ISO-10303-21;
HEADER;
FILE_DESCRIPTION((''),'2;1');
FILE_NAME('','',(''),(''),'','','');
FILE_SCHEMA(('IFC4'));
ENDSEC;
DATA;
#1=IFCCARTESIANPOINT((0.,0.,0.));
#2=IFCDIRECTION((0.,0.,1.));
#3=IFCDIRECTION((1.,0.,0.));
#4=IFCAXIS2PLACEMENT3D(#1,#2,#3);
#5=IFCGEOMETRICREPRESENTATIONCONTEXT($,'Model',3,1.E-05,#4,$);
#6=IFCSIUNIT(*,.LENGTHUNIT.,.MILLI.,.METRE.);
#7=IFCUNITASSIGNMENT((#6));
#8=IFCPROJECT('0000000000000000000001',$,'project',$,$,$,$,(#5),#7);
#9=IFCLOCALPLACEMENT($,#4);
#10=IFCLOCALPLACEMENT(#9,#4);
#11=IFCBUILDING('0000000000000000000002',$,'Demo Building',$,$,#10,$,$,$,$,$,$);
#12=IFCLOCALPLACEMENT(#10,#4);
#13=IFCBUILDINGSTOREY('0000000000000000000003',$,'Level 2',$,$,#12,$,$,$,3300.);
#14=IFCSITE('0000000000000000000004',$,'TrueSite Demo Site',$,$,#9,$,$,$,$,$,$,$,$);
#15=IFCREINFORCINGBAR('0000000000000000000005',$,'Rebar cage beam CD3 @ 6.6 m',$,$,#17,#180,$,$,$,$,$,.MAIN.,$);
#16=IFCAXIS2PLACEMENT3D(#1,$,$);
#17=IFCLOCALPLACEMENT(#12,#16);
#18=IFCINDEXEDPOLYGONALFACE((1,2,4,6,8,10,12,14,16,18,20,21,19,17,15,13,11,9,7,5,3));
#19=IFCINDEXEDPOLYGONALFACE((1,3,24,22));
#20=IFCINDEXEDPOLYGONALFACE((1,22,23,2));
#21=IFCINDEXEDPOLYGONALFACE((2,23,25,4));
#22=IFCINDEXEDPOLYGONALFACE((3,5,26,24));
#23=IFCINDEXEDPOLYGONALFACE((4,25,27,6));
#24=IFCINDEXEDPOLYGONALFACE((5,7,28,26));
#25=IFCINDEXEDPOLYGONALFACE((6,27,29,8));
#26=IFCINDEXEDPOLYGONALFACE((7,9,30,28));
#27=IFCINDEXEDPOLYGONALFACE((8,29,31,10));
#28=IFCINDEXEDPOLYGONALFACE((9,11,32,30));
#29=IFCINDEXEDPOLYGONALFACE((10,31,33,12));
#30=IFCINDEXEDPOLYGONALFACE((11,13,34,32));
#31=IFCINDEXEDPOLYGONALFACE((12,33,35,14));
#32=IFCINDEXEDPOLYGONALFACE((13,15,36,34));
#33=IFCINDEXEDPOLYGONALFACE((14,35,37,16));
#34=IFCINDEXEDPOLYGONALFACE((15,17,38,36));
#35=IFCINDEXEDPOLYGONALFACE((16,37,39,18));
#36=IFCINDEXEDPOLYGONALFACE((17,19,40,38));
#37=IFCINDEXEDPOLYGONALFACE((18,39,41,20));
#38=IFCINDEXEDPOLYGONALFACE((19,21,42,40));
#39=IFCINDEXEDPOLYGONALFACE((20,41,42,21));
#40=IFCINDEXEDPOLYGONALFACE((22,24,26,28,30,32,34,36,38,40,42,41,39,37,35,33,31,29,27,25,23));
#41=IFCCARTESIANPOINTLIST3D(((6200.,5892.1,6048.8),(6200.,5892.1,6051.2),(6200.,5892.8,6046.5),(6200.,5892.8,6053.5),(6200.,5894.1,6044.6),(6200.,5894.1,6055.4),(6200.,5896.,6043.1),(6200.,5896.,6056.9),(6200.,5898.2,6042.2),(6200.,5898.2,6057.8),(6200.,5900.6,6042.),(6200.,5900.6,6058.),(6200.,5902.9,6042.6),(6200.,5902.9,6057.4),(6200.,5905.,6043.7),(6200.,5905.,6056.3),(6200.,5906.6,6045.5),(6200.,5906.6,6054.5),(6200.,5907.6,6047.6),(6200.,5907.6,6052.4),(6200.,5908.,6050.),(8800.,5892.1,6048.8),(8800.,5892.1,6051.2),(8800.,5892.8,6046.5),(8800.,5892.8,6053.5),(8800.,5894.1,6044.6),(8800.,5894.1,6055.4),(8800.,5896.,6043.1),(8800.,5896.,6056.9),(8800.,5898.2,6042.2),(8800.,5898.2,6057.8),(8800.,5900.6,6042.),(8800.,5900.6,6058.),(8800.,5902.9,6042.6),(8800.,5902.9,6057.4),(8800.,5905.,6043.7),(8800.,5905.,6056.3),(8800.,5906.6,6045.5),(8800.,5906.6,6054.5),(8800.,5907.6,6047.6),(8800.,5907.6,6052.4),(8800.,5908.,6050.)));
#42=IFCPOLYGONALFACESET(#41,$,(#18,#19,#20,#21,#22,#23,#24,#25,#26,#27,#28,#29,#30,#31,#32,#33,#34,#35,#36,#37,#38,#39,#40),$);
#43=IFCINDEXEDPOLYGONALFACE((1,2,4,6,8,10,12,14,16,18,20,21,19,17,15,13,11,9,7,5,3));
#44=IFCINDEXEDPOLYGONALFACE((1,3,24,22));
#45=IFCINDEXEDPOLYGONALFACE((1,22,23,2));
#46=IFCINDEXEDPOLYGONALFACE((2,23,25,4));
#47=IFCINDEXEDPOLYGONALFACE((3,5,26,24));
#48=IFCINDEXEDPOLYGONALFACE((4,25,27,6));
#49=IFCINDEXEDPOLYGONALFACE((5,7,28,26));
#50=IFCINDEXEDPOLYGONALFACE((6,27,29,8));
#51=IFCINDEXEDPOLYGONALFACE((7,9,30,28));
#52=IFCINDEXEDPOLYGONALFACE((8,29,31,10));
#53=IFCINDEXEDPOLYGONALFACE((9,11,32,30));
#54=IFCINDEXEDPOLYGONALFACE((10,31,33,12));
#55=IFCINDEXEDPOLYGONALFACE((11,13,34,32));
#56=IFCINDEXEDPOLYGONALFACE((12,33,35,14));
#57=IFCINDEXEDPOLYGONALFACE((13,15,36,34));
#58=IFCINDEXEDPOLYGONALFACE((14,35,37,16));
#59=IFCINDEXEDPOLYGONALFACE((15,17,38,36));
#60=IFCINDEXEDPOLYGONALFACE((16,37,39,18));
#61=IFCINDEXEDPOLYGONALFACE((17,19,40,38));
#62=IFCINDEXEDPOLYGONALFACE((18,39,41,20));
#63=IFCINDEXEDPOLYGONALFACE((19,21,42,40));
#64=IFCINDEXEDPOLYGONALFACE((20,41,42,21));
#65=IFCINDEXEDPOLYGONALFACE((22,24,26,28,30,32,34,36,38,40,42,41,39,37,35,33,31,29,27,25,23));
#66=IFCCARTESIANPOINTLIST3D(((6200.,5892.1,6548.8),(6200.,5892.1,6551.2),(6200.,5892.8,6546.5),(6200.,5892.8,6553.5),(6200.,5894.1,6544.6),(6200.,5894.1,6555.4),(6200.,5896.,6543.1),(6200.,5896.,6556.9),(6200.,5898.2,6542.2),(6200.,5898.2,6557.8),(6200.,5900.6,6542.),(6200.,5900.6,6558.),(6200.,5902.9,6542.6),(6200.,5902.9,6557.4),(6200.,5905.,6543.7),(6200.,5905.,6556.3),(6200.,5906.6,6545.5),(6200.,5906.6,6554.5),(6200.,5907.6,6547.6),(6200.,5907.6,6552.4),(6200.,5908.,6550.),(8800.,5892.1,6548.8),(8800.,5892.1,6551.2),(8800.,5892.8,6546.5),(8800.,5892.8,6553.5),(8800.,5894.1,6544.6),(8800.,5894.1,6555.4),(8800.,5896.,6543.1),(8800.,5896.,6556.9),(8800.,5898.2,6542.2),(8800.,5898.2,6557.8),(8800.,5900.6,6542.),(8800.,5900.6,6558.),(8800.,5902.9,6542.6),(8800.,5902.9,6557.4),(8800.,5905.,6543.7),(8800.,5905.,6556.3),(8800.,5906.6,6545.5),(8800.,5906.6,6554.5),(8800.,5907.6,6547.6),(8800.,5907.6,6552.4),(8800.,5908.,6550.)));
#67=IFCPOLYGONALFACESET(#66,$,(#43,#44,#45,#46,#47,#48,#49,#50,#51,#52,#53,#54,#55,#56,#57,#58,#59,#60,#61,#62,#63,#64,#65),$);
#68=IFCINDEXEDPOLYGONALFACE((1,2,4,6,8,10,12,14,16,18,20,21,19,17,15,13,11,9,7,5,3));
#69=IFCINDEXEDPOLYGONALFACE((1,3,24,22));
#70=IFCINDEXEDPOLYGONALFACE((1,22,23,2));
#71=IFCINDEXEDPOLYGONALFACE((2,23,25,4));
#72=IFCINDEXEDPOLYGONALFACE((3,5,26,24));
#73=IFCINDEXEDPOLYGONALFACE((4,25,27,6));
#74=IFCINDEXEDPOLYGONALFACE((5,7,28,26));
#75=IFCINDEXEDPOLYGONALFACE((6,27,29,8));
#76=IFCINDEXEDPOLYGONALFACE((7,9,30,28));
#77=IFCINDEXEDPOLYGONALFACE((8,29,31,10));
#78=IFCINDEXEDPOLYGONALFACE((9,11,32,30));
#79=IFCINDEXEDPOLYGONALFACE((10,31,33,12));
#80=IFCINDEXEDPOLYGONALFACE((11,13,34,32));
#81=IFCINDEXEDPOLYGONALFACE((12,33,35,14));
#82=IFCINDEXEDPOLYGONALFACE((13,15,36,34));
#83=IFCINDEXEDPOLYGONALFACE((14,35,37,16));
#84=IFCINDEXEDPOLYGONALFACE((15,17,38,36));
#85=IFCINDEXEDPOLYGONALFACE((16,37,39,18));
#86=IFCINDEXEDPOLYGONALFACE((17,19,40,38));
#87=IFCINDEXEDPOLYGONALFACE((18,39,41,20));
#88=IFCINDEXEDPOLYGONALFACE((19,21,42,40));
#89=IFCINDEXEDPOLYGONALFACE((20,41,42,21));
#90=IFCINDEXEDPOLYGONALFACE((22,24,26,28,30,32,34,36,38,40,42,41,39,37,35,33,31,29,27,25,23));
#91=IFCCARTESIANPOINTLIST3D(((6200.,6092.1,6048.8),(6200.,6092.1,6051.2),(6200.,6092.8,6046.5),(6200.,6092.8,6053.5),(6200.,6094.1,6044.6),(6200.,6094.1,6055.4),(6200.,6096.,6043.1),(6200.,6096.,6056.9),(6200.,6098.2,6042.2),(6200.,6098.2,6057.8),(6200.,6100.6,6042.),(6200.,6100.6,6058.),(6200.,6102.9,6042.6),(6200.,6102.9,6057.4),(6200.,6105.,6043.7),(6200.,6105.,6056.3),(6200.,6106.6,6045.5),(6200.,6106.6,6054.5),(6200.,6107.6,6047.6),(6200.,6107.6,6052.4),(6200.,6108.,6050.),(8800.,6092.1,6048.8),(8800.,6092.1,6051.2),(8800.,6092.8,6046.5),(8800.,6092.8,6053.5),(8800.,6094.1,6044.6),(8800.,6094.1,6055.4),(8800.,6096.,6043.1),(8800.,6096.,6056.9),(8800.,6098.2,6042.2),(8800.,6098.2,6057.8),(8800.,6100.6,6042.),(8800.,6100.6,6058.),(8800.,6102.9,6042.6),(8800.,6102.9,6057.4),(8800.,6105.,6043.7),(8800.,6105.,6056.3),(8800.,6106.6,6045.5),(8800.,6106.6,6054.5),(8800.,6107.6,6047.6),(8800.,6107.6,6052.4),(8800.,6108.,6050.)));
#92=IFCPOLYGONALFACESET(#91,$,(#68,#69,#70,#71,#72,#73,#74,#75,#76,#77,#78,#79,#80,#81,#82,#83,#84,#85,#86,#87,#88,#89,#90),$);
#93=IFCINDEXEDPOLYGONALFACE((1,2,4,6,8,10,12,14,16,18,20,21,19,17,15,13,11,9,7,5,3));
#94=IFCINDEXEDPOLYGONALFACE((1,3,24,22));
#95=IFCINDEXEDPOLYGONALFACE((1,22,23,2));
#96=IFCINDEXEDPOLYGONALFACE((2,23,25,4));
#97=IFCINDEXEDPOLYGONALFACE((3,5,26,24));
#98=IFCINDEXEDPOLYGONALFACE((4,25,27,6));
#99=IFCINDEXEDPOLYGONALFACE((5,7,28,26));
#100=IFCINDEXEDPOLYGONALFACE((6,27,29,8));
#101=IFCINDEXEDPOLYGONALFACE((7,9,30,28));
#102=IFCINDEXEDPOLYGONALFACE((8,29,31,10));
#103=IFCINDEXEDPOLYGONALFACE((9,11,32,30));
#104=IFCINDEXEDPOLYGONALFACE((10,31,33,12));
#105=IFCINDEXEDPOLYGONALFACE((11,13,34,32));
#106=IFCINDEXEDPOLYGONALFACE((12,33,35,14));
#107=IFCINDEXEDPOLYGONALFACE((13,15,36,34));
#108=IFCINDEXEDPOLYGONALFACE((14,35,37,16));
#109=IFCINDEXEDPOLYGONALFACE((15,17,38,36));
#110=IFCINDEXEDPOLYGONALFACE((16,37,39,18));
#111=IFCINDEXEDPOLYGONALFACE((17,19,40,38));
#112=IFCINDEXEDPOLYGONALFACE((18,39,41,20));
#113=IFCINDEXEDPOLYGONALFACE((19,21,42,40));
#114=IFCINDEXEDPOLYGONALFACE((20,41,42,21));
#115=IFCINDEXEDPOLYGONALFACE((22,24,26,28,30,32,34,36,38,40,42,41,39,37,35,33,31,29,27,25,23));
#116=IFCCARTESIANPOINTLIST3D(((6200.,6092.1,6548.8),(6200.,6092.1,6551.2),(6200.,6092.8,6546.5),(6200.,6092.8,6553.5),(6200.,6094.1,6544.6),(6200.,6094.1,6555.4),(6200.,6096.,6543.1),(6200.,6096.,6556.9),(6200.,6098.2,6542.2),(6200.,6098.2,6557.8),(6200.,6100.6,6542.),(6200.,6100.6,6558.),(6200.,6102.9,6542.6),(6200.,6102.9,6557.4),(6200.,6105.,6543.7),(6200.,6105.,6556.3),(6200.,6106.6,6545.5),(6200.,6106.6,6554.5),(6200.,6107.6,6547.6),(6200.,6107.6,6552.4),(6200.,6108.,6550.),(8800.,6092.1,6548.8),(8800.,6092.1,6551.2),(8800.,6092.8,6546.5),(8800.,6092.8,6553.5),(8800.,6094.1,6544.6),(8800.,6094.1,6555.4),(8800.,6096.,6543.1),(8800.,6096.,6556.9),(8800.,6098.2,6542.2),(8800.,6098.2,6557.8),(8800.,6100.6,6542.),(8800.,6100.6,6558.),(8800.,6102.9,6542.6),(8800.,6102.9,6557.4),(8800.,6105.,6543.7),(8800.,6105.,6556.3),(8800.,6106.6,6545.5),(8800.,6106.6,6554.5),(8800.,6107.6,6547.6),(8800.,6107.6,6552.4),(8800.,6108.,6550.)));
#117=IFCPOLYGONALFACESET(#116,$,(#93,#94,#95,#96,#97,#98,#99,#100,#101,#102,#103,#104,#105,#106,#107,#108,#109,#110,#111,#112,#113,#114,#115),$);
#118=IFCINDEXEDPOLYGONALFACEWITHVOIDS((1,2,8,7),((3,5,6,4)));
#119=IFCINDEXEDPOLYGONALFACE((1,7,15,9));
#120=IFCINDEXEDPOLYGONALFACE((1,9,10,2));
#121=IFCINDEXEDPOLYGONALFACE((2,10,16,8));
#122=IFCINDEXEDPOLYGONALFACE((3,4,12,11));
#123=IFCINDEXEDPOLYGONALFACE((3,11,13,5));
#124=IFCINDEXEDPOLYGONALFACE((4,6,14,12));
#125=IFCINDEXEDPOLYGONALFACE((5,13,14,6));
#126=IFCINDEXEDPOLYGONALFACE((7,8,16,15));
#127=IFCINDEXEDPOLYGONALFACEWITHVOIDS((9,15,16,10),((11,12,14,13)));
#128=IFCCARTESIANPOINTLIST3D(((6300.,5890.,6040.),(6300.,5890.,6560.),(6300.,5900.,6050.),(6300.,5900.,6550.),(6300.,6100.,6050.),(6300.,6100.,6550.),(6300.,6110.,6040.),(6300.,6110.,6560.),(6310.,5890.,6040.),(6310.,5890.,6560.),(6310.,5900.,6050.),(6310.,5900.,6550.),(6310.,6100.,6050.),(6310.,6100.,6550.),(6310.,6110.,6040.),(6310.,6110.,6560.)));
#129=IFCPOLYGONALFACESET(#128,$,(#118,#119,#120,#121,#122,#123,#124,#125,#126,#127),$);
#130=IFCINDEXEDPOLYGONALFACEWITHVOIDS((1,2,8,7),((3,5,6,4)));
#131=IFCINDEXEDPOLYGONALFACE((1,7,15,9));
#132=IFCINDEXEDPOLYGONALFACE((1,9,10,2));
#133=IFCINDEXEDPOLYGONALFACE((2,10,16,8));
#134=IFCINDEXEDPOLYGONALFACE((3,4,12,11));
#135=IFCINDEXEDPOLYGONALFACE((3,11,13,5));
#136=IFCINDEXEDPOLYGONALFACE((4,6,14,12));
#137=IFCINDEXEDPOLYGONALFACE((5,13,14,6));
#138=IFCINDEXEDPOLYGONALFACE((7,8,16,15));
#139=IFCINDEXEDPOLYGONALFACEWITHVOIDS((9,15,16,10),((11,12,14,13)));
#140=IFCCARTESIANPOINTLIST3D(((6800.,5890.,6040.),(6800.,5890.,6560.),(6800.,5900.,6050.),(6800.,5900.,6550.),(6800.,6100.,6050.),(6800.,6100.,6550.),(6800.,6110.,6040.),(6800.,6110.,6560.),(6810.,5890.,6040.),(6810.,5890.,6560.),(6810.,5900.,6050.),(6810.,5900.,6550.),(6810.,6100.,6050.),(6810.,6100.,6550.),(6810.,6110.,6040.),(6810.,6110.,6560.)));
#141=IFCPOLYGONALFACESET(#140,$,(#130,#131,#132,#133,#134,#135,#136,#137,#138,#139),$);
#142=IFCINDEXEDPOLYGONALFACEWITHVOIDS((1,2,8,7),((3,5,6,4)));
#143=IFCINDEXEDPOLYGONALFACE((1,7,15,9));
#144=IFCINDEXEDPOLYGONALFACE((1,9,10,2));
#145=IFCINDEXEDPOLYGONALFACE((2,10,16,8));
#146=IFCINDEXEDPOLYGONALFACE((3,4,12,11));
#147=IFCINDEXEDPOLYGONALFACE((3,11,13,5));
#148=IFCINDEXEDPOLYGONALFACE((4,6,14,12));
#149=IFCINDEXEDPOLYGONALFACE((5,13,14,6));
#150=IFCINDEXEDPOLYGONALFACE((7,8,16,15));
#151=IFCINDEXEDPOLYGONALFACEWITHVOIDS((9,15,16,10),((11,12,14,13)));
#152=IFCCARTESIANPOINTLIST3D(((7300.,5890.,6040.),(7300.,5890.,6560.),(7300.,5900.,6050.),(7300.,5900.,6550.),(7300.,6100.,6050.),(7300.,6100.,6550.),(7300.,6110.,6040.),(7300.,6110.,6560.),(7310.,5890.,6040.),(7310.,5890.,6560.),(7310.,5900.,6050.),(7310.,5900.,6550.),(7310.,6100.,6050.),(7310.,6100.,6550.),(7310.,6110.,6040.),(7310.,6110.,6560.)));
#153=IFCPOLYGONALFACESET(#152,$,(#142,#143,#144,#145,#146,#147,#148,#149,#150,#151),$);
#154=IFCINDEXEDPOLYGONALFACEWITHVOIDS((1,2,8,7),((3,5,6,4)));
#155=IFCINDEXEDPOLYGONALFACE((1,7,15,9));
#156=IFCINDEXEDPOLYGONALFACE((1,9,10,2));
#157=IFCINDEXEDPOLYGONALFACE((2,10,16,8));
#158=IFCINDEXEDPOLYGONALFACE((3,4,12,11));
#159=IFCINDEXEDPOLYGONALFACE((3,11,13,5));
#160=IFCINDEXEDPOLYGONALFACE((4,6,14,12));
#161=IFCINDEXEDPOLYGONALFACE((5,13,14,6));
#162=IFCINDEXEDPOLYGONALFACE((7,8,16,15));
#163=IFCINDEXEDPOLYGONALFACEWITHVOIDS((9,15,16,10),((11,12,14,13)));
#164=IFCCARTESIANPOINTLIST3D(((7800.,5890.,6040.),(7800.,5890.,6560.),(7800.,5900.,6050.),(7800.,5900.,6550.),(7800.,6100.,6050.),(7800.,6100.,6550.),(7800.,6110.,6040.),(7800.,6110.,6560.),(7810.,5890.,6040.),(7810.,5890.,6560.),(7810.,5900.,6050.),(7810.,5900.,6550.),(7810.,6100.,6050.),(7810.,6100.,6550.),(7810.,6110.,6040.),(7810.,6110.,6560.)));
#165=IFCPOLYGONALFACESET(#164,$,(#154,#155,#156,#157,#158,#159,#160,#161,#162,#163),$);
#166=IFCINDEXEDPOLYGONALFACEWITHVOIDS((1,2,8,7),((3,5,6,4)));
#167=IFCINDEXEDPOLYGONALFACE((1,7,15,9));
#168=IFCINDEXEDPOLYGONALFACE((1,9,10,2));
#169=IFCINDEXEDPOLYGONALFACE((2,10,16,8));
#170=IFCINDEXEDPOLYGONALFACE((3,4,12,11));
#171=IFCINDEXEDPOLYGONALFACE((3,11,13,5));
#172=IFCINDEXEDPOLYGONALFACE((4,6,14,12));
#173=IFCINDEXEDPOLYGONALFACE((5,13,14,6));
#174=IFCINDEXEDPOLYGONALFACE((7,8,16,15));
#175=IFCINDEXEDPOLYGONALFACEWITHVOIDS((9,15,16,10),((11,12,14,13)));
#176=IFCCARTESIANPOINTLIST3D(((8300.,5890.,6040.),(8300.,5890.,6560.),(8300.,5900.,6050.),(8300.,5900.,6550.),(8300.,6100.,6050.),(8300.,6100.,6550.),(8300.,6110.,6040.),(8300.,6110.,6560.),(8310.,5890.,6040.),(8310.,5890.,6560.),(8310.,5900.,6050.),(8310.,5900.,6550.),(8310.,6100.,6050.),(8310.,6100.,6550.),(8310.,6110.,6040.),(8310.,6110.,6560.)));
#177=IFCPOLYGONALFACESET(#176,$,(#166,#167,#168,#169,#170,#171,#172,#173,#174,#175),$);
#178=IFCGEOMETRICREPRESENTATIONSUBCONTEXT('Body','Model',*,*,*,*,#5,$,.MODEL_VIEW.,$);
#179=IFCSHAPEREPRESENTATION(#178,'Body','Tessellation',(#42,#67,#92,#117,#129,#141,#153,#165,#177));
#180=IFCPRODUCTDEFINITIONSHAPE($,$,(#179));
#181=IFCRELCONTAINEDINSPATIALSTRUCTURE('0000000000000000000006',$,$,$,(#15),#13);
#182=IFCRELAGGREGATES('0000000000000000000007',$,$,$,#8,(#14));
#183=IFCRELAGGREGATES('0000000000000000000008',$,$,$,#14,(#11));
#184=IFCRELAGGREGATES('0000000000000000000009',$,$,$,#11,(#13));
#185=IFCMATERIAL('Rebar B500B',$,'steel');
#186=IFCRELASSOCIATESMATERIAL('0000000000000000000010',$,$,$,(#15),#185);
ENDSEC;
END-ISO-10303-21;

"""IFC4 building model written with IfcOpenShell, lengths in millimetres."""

from ifc_helpers import new_model, si_unit, frame, origin_with_axes, place, context, subcontext, project, spatial, hollow_rectangle, circle, extrude, material, element, save


model = new_model("IFC4")

# Units and contexts
model_context = context("Model", 3, precision=1e-05, world=origin_with_axes())
body_context = subcontext(model_context, "Body", "Model", "MODEL_VIEW")
ifc_project = project(units=[si_unit("LENGTHUNIT", "METRE", prefix="MILLI")], contexts=[model_context])

# Site, building, storey
site_placement = place(None, origin_with_axes())
site = spatial("IfcSite", under=ifc_project, at=site_placement, Name="TrueSite Demo Site")
building_placement = place(site_placement, origin_with_axes())
building = spatial("IfcBuilding", under=site, at=building_placement, Name="Demo Building")
storey_placement = place(building_placement, origin_with_axes())
storey = spatial("IfcBuildingStorey", under=building, at=storey_placement, Name="Level 2", Elevation=3300.0)

# Reinforcing bar
ifc_material_1 = material(Name="Rebar B500B", Category="steel")
for number, where, z_axis, x_axis, name in (
    (1, (6200.0, 6000.0, 6300.0), (1.0, 0.0, 0.0), (0.0, 1.0, 0.0), "Rebar cage beam CD3 @ 6.6 m"),
):
    element("IfcReinforcingBar", number, at=place(storey_placement, frame(where, z_axis=z_axis, x_axis=x_axis)), inside=storey, material=ifc_material_1, Name=name, PredefinedType="MAIN", context=body_context, shape_type="SweptSolid", body=[
        extrude(circle(Radius=8.0), frame((-100.0, -250.0, 0.0)), (0.0, 0.0, 1.0), 2600.0),
        extrude(circle(Radius=8.0), frame((-100.0, 250.0, 0.0)), (0.0, 0.0, 1.0), 2600.0),
        extrude(circle(Radius=8.0), frame((100.0, -250.0, 0.0)), (0.0, 0.0, 1.0), 2600.0),
        extrude(circle(Radius=8.0), frame((100.0, 250.0, 0.0)), (0.0, 0.0, 1.0), 2600.0),
        extrude(hollow_rectangle(XDim=220.0, YDim=520.0, WallThickness=10.0), frame((0.0, 0.0, 100.0)), (0.0, 0.0, 1.0), 10.0),
        extrude(hollow_rectangle(XDim=220.0, YDim=520.0, WallThickness=10.0), frame((0.0, 0.0, 600.0)), (0.0, 0.0, 1.0), 10.0),
        extrude(hollow_rectangle(XDim=220.0, YDim=520.0, WallThickness=10.0), frame((0.0, 0.0, 1100.0)), (0.0, 0.0, 1.0), 10.0),
        extrude(hollow_rectangle(XDim=220.0, YDim=520.0, WallThickness=10.0), frame((0.0, 0.0, 1600.0)), (0.0, 0.0, 1.0), 10.0),
        extrude(hollow_rectangle(XDim=220.0, YDim=520.0, WallThickness=10.0), frame((0.0, 0.0, 2100.0)), (0.0, 0.0, 1.0), 10.0),
    ])

save(model, "model.ifc")
